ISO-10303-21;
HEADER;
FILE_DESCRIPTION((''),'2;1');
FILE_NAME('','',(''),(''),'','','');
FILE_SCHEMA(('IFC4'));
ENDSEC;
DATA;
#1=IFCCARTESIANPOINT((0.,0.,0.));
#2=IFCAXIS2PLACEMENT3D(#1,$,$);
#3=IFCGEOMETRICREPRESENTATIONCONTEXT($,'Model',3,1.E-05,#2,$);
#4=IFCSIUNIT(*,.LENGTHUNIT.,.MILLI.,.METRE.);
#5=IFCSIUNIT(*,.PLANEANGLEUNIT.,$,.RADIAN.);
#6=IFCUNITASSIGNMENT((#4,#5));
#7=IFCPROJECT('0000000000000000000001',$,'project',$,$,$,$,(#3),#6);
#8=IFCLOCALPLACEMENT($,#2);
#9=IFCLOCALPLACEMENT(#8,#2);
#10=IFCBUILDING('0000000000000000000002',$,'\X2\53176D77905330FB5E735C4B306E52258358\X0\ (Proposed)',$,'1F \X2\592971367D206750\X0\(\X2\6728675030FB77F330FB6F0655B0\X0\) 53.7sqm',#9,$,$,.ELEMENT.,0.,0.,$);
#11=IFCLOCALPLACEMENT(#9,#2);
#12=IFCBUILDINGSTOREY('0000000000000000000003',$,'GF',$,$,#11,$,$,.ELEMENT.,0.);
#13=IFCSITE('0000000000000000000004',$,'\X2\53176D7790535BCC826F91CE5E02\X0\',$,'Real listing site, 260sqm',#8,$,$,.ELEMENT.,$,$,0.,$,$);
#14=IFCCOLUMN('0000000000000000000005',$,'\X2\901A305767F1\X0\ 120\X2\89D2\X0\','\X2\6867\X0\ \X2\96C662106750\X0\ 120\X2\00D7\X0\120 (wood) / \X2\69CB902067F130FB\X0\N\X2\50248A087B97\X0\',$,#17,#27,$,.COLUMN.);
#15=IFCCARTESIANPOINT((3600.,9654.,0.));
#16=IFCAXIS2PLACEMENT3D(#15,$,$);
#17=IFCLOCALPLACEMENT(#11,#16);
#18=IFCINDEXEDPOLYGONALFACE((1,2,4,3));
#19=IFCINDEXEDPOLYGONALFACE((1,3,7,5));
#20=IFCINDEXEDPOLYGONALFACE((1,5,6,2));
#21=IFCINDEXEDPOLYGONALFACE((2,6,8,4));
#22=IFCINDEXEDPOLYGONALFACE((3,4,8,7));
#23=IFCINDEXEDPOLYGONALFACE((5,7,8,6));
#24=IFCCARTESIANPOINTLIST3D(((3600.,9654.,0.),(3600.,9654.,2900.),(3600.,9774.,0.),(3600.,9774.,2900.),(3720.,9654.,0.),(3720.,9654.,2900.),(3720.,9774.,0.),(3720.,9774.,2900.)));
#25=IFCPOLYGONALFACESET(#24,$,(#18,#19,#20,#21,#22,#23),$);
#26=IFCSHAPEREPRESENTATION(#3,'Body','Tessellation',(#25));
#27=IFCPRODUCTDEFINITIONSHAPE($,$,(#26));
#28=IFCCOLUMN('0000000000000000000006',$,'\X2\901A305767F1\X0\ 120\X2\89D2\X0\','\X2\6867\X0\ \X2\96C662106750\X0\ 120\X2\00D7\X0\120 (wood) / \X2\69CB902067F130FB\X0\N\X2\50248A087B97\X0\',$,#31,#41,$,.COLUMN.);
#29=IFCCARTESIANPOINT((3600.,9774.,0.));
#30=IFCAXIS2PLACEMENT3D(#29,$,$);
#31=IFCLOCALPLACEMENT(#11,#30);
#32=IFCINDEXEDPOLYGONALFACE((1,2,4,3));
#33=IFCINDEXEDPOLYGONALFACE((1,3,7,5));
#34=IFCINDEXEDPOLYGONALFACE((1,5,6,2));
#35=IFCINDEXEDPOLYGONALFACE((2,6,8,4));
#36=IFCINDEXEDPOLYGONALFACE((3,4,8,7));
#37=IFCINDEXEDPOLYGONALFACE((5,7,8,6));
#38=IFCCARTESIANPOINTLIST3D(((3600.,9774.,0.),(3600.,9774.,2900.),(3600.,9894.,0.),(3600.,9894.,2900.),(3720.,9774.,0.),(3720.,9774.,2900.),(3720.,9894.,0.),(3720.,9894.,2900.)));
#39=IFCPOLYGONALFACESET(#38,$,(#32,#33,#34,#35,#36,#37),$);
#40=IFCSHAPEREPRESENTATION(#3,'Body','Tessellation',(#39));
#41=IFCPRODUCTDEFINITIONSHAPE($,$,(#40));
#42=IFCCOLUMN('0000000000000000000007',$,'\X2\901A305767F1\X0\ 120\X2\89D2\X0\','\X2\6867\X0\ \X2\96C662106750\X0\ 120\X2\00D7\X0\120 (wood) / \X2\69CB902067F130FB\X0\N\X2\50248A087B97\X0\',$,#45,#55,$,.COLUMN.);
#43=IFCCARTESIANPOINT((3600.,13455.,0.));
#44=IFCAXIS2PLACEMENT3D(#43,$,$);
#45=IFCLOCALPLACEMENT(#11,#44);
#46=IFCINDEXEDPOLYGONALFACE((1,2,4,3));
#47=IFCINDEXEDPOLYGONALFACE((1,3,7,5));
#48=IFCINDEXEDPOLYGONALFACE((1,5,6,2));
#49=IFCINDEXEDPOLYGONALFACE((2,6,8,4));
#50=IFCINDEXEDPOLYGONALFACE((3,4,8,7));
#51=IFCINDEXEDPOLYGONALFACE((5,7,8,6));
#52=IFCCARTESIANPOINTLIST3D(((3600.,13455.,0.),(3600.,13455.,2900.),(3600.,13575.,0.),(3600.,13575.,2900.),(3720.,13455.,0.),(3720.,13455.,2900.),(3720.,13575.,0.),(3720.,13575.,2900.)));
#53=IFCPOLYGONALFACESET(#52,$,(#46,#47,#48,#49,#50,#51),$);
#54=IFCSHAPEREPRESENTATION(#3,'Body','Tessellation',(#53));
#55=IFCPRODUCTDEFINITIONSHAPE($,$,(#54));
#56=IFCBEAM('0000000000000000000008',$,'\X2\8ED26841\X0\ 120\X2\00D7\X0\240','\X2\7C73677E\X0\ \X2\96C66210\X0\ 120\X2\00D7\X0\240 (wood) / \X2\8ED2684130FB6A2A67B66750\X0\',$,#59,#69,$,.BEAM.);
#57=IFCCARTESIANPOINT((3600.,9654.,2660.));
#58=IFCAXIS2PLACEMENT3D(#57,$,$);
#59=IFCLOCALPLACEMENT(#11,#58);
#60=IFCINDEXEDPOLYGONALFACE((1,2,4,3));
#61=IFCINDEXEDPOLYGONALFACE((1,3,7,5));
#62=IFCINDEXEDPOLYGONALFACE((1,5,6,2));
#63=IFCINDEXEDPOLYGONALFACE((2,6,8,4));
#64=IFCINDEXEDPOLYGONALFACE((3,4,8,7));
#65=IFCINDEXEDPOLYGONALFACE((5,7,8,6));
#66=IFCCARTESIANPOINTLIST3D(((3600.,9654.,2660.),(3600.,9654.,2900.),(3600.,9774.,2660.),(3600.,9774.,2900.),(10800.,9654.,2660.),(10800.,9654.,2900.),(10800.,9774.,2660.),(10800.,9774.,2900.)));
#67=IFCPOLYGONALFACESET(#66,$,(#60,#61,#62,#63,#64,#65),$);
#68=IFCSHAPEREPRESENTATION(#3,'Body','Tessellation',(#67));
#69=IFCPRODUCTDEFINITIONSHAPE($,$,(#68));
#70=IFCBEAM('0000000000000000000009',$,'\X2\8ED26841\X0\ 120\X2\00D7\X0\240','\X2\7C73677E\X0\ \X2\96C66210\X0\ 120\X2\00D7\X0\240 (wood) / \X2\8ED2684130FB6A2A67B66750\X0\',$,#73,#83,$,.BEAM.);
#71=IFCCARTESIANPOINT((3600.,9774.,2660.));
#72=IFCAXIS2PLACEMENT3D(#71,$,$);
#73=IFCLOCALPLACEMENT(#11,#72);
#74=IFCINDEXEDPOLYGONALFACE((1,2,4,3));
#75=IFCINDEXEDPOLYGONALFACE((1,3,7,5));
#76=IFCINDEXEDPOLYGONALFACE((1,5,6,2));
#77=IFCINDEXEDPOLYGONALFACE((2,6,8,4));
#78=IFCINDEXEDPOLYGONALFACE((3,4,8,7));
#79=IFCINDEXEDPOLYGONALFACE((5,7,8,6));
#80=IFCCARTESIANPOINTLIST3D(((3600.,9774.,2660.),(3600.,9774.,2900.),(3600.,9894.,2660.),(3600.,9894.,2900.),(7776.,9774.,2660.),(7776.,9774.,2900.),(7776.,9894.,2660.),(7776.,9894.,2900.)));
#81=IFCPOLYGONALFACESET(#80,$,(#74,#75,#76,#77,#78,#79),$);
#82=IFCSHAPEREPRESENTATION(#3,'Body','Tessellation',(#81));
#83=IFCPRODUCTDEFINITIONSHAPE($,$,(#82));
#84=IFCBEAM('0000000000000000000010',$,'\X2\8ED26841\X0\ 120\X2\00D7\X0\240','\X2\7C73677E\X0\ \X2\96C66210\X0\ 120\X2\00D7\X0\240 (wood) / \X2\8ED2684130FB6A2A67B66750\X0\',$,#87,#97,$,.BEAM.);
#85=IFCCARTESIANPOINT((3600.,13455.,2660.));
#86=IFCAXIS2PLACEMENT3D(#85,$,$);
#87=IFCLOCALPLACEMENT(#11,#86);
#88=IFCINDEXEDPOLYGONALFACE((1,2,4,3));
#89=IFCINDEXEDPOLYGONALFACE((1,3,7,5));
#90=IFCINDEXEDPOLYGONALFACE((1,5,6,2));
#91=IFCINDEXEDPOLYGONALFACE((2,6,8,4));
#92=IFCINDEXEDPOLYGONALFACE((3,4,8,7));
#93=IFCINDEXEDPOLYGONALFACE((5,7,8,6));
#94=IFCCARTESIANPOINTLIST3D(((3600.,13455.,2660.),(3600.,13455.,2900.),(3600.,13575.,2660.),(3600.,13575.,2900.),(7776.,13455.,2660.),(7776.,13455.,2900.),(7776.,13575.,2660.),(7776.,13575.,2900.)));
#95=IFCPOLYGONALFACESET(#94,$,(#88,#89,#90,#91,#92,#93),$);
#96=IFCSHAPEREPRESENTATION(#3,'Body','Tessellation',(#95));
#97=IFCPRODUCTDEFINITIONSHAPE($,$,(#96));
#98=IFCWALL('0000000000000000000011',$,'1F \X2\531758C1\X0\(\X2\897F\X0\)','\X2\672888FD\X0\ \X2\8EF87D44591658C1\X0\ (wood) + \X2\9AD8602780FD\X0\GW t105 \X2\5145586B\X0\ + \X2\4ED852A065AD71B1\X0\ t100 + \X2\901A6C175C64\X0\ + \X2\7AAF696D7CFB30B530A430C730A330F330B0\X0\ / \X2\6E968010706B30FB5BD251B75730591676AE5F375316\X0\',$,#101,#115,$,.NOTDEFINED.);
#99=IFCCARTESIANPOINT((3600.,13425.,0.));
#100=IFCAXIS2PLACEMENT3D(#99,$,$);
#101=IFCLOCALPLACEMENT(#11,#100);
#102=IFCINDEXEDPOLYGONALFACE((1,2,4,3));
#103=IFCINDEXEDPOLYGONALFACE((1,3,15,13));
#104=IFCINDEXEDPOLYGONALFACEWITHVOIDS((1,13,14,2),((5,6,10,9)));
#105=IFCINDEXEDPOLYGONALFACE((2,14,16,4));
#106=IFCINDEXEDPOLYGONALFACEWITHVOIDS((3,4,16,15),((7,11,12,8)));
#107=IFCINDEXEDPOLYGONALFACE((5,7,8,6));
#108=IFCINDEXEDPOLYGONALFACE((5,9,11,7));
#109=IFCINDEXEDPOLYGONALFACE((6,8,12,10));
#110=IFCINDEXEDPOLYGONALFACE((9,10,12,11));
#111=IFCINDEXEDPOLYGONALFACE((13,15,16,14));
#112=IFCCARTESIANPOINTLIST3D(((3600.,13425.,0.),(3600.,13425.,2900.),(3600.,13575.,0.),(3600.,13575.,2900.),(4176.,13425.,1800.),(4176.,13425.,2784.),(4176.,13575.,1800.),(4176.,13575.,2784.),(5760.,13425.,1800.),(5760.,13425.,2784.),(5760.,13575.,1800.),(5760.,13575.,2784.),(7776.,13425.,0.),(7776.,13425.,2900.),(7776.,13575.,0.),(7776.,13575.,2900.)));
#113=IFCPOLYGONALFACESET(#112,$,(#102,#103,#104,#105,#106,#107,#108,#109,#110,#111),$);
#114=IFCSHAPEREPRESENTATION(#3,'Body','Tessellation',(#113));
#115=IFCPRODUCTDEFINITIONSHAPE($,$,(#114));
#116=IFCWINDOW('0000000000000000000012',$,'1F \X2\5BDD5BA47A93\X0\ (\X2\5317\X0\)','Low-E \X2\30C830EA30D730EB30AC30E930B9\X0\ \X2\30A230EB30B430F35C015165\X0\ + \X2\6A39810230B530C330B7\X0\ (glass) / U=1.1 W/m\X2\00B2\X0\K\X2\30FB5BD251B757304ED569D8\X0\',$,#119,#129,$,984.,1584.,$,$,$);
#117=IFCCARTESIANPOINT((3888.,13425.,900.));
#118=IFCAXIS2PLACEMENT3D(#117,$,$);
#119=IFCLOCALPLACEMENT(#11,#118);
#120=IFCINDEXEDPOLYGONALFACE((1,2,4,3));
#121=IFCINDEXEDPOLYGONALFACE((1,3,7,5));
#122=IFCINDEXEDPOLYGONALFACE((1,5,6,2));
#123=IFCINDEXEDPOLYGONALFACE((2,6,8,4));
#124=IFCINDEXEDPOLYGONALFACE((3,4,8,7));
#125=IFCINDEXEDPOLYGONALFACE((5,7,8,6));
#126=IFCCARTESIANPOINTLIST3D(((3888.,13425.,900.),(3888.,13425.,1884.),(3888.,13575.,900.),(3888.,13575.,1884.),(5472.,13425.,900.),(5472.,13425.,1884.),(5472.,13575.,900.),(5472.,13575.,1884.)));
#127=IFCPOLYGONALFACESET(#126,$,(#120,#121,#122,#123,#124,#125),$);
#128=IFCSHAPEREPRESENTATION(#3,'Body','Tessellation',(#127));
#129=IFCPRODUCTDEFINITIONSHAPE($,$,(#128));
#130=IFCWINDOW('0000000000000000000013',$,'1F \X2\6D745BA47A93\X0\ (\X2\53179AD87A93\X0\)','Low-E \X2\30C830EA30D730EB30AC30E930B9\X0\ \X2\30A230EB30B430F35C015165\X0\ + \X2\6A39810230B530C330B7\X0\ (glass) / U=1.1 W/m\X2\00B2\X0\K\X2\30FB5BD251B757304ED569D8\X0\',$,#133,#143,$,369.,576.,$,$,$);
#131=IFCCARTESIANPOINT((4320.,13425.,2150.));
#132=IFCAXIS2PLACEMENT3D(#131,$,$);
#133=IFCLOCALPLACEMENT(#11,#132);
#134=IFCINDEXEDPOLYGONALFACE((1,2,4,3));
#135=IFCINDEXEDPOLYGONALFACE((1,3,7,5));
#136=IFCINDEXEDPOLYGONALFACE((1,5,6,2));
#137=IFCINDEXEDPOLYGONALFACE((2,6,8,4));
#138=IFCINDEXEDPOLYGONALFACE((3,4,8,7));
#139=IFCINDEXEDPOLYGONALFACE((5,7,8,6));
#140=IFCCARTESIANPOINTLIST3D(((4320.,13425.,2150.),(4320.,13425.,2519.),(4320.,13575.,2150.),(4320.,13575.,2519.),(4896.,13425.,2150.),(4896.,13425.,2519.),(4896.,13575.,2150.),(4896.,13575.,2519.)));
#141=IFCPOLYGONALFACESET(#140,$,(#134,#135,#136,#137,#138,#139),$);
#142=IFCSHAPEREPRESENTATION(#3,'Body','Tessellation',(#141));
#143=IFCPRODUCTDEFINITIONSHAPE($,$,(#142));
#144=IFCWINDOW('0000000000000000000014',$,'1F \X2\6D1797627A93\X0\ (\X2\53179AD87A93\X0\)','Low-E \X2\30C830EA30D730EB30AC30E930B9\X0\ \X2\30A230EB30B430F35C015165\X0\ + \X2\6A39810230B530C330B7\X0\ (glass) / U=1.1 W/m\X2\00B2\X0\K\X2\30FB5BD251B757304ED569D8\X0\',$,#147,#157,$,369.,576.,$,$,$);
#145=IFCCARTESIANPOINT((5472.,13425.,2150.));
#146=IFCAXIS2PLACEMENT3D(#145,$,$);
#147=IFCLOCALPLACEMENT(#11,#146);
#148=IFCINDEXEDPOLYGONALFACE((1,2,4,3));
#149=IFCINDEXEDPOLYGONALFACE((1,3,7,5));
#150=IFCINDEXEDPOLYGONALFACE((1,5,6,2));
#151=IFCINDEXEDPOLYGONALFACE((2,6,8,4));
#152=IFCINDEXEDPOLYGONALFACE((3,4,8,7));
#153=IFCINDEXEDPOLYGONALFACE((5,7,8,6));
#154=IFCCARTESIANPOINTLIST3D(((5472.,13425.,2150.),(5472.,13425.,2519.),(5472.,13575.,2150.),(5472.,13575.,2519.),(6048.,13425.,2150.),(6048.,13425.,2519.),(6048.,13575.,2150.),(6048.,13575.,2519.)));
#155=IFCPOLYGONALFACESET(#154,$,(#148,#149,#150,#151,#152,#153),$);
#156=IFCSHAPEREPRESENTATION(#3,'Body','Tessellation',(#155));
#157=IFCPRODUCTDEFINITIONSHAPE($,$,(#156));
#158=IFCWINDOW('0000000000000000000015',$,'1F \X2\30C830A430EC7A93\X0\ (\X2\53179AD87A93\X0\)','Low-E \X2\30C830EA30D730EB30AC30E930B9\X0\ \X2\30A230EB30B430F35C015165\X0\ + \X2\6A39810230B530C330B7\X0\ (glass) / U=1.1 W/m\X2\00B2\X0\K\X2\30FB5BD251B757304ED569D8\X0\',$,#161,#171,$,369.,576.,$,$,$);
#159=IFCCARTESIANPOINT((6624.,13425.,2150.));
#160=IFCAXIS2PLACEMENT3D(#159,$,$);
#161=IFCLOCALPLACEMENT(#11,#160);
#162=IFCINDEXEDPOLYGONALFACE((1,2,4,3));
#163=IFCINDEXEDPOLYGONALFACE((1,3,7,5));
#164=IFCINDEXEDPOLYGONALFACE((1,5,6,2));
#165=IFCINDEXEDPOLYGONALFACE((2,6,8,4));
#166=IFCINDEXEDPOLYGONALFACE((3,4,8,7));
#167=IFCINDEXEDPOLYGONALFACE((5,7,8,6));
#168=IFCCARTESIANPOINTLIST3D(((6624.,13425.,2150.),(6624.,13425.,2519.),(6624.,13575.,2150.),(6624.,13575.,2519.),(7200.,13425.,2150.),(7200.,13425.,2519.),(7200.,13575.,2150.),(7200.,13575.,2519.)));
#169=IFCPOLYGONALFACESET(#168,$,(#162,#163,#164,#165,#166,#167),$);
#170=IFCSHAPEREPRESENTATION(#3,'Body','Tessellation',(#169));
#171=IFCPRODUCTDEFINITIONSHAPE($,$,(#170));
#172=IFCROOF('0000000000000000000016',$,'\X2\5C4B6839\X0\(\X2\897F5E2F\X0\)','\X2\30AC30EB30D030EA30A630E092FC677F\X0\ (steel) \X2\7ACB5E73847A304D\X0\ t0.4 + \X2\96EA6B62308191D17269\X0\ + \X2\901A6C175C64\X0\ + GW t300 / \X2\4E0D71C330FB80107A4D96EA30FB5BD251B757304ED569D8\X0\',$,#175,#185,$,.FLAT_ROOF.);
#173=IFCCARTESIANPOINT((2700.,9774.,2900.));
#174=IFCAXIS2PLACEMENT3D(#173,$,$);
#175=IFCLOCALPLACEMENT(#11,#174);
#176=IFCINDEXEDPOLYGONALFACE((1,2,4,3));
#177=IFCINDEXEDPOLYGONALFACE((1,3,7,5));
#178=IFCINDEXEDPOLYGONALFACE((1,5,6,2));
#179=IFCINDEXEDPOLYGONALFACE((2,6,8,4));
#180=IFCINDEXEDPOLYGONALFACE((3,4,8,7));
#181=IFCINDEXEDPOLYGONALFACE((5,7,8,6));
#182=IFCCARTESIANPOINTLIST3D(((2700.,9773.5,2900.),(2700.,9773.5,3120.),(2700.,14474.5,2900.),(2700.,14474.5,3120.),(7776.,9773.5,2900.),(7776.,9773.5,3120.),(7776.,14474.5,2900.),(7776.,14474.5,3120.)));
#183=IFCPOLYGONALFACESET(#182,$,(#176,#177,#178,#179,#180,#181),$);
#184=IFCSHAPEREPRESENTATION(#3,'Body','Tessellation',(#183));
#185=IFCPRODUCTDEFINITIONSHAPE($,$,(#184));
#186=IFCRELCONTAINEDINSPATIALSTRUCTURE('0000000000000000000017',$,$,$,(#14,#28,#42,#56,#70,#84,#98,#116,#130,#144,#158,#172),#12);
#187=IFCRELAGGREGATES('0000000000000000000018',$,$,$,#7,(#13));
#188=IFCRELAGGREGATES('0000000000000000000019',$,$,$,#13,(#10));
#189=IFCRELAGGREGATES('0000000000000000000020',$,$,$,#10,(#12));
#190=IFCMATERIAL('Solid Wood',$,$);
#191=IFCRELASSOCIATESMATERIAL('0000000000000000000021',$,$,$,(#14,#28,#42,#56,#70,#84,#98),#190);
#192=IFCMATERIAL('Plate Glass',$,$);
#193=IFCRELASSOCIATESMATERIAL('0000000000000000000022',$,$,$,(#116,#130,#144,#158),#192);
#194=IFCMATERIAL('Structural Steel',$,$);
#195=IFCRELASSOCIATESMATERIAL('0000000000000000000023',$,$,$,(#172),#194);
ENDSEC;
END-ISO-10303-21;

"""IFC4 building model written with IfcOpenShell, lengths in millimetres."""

from ifc_helpers import new_model, si_unit, frame, frame_2d, origin, place, context, project, spatial, rectangle, extrude, material, element, fill, save


model = new_model("IFC4")

# Units and contexts
model_context = context("Model", 3, precision=1e-05, world=origin())
ifc_project = project(units=[si_unit("LENGTHUNIT", "METRE", prefix="MILLI"), si_unit("PLANEANGLEUNIT", "RADIAN")], contexts=[model_context])

# Site, building, storey
site_placement = place(None, origin())
site = spatial("IfcSite", under=ifc_project, at=site_placement, Name="北海道富良野市", ObjectType="Real listing site, 260sqm", CompositionType="ELEMENT", RefElevation=0.0)
building_placement = place(site_placement, origin())
building = spatial("IfcBuilding", under=site, at=building_placement, Name="北海道・平屋の別荘 (Proposed)", ObjectType="1F 天然素材(木材・石・漆喰) 53.7sqm", CompositionType="ELEMENT", ElevationOfRefHeight=0.0, ElevationOfTerrain=0.0)
storey_placement = place(building_placement, origin())
storey = spatial("IfcBuildingStorey", under=building, at=storey_placement, Name="GF", CompositionType="ELEMENT", Elevation=0.0)

# Columns
ifc_material_1 = material(Name="Solid Wood")
column_1_placement = place(storey_placement, frame((3600.0, 9654.0, 0.0)))
element("IfcColumn", 1, at=column_1_placement, inside=storey, material=ifc_material_1, Name="通し柱 120角", Description="桧 集成材 120×120 (wood) / 構造柱・N値計算", PredefinedType="COLUMN", context=model_context, shape_type="SweptSolid", body=[
    extrude(rectangle(XDim=120.0, YDim=120.0, at=frame_2d((60.0, 60.0))), frame((3600.0, 9654.0, 0.0)), (0.0, 0.0, 1.0), 2900.0),
])
column_2_placement = place(storey_placement, frame((3600.0, 9774.0, 0.0)))
element("IfcColumn", 2, at=column_2_placement, inside=storey, material=ifc_material_1, Name="通し柱 120角", Description="桧 集成材 120×120 (wood) / 構造柱・N値計算", PredefinedType="COLUMN", context=model_context, shape_type="SweptSolid", body=[
    extrude(rectangle(XDim=120.0, YDim=120.0, at=frame_2d((60.0, 60.0))), frame((3600.0, 9774.0, 0.0)), (0.0, 0.0, 1.0), 2900.0),
])
column_3_placement = place(storey_placement, frame((3600.0, 13455.0, 0.0)))
element("IfcColumn", 3, at=column_3_placement, inside=storey, material=ifc_material_1, Name="通し柱 120角", Description="桧 集成材 120×120 (wood) / 構造柱・N値計算", PredefinedType="COLUMN", context=model_context, shape_type="SweptSolid", body=[
    extrude(rectangle(XDim=120.0, YDim=120.0, at=frame_2d((60.0, 60.0))), frame((3600.0, 13455.0, 0.0)), (0.0, 0.0, 1.0), 2900.0),
])

# Beams
beam_1_placement = place(storey_placement, frame((3600.0, 9654.0, 2660.0)))
element("IfcBeam", 4, at=beam_1_placement, inside=storey, material=ifc_material_1, Name="軒桁 120×240", Description="米松 集成 120×240 (wood) / 軒桁・横架材", PredefinedType="BEAM", context=model_context, shape_type="SweptSolid", body=[
    extrude(rectangle(XDim=7200.0, YDim=120.0, at=frame_2d((3600.0, 60.0))), frame((3600.0, 9654.0, 2660.0)), (0.0, 0.0, 1.0), 240.0),
])
beam_2_placement = place(storey_placement, frame((3600.0, 9774.0, 2660.0)))
element("IfcBeam", 5, at=beam_2_placement, inside=storey, material=ifc_material_1, Name="軒桁 120×240", Description="米松 集成 120×240 (wood) / 軒桁・横架材", PredefinedType="BEAM", context=model_context, shape_type="SweptSolid", body=[
    extrude(rectangle(XDim=4176.0, YDim=120.0, at=frame_2d((2088.0, 60.0))), frame((3600.0, 9774.0, 2660.0)), (0.0, 0.0, 1.0), 240.0),
])
beam_3_placement = place(storey_placement, frame((3600.0, 13455.0, 2660.0)))
element("IfcBeam", 6, at=beam_3_placement, inside=storey, material=ifc_material_1, Name="軒桁 120×240", Description="米松 集成 120×240 (wood) / 軒桁・横架材", PredefinedType="BEAM", context=model_context, shape_type="SweptSolid", body=[
    extrude(rectangle(XDim=4176.0, YDim=120.0, at=frame_2d((2088.0, 60.0))), frame((3600.0, 13455.0, 2660.0)), (0.0, 0.0, 1.0), 240.0),
])

# Wall, openings, windows
wall_1_placement = place(storey_placement, frame((3600.0, 13425.0, 0.0)))
wall_1 = element("IfcWall", 7, at=wall_1_placement, inside=storey, material=ifc_material_1, Name="1F 北壁(西)", Description="木製 軸組外壁 (wood) + 高性能GW t105 充填 + 付加断熱 t100 + 通気層 + 窯業系サイディング / 準耐火・寒冷地外皮強化", PredefinedType="NOTDEFINED", context=model_context, shape_type="SweptSolid", body=[
    extrude(rectangle(XDim=4176.0, YDim=150.0, at=frame_2d((2088.0, 75.0))), frame((3600.0, 13425.0, 0.0)), (0.0, 0.0, 1.0), 2900.0),
])
opening_1_placement = place(storey_placement, frame((3888.0, 13425.0, 900.0)))
opening_1 = element("IfcOpeningElement", 8, at=opening_1_placement, cuts=wall_1, PredefinedType="NOTDEFINED", context=model_context, shape_type="SweptSolid", body=[
    extrude(rectangle(XDim=1584.0, YDim=150.0, at=frame_2d((792.0, 75.0))), frame((3888.0, 13425.0, 900.0)), (0.0, 0.0, 1.0), 984.0),
])
opening_2_placement = place(storey_placement, frame((4320.0, 13425.0, 2150.0)))
opening_2 = element("IfcOpeningElement", 9, at=opening_2_placement, cuts=wall_1, PredefinedType="NOTDEFINED", context=model_context, shape_type="SweptSolid", body=[
    extrude(rectangle(XDim=576.0, YDim=150.0, at=frame_2d((288.0, 75.0))), frame((4320.0, 13425.0, 2150.0)), (0.0, 0.0, 1.0), 369.0),
])
opening_3_placement = place(storey_placement, frame((5472.0, 13425.0, 2150.0)))
opening_3 = element("IfcOpeningElement", 10, at=opening_3_placement, cuts=wall_1, PredefinedType="NOTDEFINED", context=model_context, shape_type="SweptSolid", body=[
    extrude(rectangle(XDim=576.0, YDim=150.0, at=frame_2d((288.0, 75.0))), frame((5472.0, 13425.0, 2150.0)), (0.0, 0.0, 1.0), 369.0),
])
opening_4_placement = place(storey_placement, frame((6624.0, 13425.0, 2150.0)))
opening_4 = element("IfcOpeningElement", 11, at=opening_4_placement, cuts=wall_1, PredefinedType="NOTDEFINED", context=model_context, shape_type="SweptSolid", body=[
    extrude(rectangle(XDim=576.0, YDim=150.0, at=frame_2d((288.0, 75.0))), frame((6624.0, 13425.0, 2150.0)), (0.0, 0.0, 1.0), 369.0),
])
ifc_material_2 = material(Name="Plate Glass")
window_1_placement = place(storey_placement, frame((3888.0, 13425.0, 900.0)))
window_1 = element("IfcWindow", 12, at=window_1_placement, inside=storey, material=ifc_material_2, Name="1F 寝室窓 (北)", Description="Low-E トリプルガラス アルゴン封入 + 樹脂サッシ (glass) / U=1.1 W/m²K・寒冷地仕様", OverallHeight=984.0, OverallWidth=1584.0, context=model_context, shape_type="SweptSolid", body=[
    extrude(rectangle(XDim=1584.0, YDim=150.0, at=frame_2d((792.0, 75.0))), frame((3888.0, 13425.0, 900.0)), (0.0, 0.0, 1.0), 984.0),
])
fill(opening_1, window_1)
window_2_placement = place(storey_placement, frame((4320.0, 13425.0, 2150.0)))
window_2 = element("IfcWindow", 13, at=window_2_placement, inside=storey, material=ifc_material_2, Name="1F 浴室窓 (北高窓)", Description="Low-E トリプルガラス アルゴン封入 + 樹脂サッシ (glass) / U=1.1 W/m²K・寒冷地仕様", OverallHeight=369.0, OverallWidth=576.0, context=model_context, shape_type="SweptSolid", body=[
    extrude(rectangle(XDim=576.0, YDim=150.0, at=frame_2d((288.0, 75.0))), frame((4320.0, 13425.0, 2150.0)), (0.0, 0.0, 1.0), 369.0),
])
fill(opening_2, window_2)
window_3_placement = place(storey_placement, frame((5472.0, 13425.0, 2150.0)))
window_3 = element("IfcWindow", 14, at=window_3_placement, inside=storey, material=ifc_material_2, Name="1F 洗面窓 (北高窓)", Description="Low-E トリプルガラス アルゴン封入 + 樹脂サッシ (glass) / U=1.1 W/m²K・寒冷地仕様", OverallHeight=369.0, OverallWidth=576.0, context=model_context, shape_type="SweptSolid", body=[
    extrude(rectangle(XDim=576.0, YDim=150.0, at=frame_2d((288.0, 75.0))), frame((5472.0, 13425.0, 2150.0)), (0.0, 0.0, 1.0), 369.0),
])
fill(opening_3, window_3)
window_4_placement = place(storey_placement, frame((6624.0, 13425.0, 2150.0)))
window_4 = element("IfcWindow", 15, at=window_4_placement, inside=storey, material=ifc_material_2, Name="1F トイレ窓 (北高窓)", Description="Low-E トリプルガラス アルゴン封入 + 樹脂サッシ (glass) / U=1.1 W/m²K・寒冷地仕様", OverallHeight=369.0, OverallWidth=576.0, context=model_context, shape_type="SweptSolid", body=[
    extrude(rectangle(XDim=576.0, YDim=150.0, at=frame_2d((288.0, 75.0))), frame((6624.0, 13425.0, 2150.0)), (0.0, 0.0, 1.0), 369.0),
])
fill(opening_4, window_4)

# Roof
ifc_material_3 = material(Name="Structural Steel")
roof_placement = place(storey_placement, frame((2700.0, 9774.0, 2900.0)))
element("IfcRoof", 16, at=roof_placement, inside=storey, material=ifc_material_3, Name="屋根(西帯)", Description="ガルバリウム鋼板 (steel) 立平葺き t0.4 + 雪止め金物 + 通気層 + GW t300 / 不燃・耐積雪・寒冷地仕様", PredefinedType="FLAT_ROOF", context=model_context, shape_type="SweptSolid", body=[
    extrude(rectangle(XDim=5076.0, YDim=4701.0, at=frame_2d((2538.0, 2350.0))), frame((2700.0, 9774.0, 2900.0)), (0.0, 0.0, 1.0), 220.0),
])

save(model, "model.ifc")
